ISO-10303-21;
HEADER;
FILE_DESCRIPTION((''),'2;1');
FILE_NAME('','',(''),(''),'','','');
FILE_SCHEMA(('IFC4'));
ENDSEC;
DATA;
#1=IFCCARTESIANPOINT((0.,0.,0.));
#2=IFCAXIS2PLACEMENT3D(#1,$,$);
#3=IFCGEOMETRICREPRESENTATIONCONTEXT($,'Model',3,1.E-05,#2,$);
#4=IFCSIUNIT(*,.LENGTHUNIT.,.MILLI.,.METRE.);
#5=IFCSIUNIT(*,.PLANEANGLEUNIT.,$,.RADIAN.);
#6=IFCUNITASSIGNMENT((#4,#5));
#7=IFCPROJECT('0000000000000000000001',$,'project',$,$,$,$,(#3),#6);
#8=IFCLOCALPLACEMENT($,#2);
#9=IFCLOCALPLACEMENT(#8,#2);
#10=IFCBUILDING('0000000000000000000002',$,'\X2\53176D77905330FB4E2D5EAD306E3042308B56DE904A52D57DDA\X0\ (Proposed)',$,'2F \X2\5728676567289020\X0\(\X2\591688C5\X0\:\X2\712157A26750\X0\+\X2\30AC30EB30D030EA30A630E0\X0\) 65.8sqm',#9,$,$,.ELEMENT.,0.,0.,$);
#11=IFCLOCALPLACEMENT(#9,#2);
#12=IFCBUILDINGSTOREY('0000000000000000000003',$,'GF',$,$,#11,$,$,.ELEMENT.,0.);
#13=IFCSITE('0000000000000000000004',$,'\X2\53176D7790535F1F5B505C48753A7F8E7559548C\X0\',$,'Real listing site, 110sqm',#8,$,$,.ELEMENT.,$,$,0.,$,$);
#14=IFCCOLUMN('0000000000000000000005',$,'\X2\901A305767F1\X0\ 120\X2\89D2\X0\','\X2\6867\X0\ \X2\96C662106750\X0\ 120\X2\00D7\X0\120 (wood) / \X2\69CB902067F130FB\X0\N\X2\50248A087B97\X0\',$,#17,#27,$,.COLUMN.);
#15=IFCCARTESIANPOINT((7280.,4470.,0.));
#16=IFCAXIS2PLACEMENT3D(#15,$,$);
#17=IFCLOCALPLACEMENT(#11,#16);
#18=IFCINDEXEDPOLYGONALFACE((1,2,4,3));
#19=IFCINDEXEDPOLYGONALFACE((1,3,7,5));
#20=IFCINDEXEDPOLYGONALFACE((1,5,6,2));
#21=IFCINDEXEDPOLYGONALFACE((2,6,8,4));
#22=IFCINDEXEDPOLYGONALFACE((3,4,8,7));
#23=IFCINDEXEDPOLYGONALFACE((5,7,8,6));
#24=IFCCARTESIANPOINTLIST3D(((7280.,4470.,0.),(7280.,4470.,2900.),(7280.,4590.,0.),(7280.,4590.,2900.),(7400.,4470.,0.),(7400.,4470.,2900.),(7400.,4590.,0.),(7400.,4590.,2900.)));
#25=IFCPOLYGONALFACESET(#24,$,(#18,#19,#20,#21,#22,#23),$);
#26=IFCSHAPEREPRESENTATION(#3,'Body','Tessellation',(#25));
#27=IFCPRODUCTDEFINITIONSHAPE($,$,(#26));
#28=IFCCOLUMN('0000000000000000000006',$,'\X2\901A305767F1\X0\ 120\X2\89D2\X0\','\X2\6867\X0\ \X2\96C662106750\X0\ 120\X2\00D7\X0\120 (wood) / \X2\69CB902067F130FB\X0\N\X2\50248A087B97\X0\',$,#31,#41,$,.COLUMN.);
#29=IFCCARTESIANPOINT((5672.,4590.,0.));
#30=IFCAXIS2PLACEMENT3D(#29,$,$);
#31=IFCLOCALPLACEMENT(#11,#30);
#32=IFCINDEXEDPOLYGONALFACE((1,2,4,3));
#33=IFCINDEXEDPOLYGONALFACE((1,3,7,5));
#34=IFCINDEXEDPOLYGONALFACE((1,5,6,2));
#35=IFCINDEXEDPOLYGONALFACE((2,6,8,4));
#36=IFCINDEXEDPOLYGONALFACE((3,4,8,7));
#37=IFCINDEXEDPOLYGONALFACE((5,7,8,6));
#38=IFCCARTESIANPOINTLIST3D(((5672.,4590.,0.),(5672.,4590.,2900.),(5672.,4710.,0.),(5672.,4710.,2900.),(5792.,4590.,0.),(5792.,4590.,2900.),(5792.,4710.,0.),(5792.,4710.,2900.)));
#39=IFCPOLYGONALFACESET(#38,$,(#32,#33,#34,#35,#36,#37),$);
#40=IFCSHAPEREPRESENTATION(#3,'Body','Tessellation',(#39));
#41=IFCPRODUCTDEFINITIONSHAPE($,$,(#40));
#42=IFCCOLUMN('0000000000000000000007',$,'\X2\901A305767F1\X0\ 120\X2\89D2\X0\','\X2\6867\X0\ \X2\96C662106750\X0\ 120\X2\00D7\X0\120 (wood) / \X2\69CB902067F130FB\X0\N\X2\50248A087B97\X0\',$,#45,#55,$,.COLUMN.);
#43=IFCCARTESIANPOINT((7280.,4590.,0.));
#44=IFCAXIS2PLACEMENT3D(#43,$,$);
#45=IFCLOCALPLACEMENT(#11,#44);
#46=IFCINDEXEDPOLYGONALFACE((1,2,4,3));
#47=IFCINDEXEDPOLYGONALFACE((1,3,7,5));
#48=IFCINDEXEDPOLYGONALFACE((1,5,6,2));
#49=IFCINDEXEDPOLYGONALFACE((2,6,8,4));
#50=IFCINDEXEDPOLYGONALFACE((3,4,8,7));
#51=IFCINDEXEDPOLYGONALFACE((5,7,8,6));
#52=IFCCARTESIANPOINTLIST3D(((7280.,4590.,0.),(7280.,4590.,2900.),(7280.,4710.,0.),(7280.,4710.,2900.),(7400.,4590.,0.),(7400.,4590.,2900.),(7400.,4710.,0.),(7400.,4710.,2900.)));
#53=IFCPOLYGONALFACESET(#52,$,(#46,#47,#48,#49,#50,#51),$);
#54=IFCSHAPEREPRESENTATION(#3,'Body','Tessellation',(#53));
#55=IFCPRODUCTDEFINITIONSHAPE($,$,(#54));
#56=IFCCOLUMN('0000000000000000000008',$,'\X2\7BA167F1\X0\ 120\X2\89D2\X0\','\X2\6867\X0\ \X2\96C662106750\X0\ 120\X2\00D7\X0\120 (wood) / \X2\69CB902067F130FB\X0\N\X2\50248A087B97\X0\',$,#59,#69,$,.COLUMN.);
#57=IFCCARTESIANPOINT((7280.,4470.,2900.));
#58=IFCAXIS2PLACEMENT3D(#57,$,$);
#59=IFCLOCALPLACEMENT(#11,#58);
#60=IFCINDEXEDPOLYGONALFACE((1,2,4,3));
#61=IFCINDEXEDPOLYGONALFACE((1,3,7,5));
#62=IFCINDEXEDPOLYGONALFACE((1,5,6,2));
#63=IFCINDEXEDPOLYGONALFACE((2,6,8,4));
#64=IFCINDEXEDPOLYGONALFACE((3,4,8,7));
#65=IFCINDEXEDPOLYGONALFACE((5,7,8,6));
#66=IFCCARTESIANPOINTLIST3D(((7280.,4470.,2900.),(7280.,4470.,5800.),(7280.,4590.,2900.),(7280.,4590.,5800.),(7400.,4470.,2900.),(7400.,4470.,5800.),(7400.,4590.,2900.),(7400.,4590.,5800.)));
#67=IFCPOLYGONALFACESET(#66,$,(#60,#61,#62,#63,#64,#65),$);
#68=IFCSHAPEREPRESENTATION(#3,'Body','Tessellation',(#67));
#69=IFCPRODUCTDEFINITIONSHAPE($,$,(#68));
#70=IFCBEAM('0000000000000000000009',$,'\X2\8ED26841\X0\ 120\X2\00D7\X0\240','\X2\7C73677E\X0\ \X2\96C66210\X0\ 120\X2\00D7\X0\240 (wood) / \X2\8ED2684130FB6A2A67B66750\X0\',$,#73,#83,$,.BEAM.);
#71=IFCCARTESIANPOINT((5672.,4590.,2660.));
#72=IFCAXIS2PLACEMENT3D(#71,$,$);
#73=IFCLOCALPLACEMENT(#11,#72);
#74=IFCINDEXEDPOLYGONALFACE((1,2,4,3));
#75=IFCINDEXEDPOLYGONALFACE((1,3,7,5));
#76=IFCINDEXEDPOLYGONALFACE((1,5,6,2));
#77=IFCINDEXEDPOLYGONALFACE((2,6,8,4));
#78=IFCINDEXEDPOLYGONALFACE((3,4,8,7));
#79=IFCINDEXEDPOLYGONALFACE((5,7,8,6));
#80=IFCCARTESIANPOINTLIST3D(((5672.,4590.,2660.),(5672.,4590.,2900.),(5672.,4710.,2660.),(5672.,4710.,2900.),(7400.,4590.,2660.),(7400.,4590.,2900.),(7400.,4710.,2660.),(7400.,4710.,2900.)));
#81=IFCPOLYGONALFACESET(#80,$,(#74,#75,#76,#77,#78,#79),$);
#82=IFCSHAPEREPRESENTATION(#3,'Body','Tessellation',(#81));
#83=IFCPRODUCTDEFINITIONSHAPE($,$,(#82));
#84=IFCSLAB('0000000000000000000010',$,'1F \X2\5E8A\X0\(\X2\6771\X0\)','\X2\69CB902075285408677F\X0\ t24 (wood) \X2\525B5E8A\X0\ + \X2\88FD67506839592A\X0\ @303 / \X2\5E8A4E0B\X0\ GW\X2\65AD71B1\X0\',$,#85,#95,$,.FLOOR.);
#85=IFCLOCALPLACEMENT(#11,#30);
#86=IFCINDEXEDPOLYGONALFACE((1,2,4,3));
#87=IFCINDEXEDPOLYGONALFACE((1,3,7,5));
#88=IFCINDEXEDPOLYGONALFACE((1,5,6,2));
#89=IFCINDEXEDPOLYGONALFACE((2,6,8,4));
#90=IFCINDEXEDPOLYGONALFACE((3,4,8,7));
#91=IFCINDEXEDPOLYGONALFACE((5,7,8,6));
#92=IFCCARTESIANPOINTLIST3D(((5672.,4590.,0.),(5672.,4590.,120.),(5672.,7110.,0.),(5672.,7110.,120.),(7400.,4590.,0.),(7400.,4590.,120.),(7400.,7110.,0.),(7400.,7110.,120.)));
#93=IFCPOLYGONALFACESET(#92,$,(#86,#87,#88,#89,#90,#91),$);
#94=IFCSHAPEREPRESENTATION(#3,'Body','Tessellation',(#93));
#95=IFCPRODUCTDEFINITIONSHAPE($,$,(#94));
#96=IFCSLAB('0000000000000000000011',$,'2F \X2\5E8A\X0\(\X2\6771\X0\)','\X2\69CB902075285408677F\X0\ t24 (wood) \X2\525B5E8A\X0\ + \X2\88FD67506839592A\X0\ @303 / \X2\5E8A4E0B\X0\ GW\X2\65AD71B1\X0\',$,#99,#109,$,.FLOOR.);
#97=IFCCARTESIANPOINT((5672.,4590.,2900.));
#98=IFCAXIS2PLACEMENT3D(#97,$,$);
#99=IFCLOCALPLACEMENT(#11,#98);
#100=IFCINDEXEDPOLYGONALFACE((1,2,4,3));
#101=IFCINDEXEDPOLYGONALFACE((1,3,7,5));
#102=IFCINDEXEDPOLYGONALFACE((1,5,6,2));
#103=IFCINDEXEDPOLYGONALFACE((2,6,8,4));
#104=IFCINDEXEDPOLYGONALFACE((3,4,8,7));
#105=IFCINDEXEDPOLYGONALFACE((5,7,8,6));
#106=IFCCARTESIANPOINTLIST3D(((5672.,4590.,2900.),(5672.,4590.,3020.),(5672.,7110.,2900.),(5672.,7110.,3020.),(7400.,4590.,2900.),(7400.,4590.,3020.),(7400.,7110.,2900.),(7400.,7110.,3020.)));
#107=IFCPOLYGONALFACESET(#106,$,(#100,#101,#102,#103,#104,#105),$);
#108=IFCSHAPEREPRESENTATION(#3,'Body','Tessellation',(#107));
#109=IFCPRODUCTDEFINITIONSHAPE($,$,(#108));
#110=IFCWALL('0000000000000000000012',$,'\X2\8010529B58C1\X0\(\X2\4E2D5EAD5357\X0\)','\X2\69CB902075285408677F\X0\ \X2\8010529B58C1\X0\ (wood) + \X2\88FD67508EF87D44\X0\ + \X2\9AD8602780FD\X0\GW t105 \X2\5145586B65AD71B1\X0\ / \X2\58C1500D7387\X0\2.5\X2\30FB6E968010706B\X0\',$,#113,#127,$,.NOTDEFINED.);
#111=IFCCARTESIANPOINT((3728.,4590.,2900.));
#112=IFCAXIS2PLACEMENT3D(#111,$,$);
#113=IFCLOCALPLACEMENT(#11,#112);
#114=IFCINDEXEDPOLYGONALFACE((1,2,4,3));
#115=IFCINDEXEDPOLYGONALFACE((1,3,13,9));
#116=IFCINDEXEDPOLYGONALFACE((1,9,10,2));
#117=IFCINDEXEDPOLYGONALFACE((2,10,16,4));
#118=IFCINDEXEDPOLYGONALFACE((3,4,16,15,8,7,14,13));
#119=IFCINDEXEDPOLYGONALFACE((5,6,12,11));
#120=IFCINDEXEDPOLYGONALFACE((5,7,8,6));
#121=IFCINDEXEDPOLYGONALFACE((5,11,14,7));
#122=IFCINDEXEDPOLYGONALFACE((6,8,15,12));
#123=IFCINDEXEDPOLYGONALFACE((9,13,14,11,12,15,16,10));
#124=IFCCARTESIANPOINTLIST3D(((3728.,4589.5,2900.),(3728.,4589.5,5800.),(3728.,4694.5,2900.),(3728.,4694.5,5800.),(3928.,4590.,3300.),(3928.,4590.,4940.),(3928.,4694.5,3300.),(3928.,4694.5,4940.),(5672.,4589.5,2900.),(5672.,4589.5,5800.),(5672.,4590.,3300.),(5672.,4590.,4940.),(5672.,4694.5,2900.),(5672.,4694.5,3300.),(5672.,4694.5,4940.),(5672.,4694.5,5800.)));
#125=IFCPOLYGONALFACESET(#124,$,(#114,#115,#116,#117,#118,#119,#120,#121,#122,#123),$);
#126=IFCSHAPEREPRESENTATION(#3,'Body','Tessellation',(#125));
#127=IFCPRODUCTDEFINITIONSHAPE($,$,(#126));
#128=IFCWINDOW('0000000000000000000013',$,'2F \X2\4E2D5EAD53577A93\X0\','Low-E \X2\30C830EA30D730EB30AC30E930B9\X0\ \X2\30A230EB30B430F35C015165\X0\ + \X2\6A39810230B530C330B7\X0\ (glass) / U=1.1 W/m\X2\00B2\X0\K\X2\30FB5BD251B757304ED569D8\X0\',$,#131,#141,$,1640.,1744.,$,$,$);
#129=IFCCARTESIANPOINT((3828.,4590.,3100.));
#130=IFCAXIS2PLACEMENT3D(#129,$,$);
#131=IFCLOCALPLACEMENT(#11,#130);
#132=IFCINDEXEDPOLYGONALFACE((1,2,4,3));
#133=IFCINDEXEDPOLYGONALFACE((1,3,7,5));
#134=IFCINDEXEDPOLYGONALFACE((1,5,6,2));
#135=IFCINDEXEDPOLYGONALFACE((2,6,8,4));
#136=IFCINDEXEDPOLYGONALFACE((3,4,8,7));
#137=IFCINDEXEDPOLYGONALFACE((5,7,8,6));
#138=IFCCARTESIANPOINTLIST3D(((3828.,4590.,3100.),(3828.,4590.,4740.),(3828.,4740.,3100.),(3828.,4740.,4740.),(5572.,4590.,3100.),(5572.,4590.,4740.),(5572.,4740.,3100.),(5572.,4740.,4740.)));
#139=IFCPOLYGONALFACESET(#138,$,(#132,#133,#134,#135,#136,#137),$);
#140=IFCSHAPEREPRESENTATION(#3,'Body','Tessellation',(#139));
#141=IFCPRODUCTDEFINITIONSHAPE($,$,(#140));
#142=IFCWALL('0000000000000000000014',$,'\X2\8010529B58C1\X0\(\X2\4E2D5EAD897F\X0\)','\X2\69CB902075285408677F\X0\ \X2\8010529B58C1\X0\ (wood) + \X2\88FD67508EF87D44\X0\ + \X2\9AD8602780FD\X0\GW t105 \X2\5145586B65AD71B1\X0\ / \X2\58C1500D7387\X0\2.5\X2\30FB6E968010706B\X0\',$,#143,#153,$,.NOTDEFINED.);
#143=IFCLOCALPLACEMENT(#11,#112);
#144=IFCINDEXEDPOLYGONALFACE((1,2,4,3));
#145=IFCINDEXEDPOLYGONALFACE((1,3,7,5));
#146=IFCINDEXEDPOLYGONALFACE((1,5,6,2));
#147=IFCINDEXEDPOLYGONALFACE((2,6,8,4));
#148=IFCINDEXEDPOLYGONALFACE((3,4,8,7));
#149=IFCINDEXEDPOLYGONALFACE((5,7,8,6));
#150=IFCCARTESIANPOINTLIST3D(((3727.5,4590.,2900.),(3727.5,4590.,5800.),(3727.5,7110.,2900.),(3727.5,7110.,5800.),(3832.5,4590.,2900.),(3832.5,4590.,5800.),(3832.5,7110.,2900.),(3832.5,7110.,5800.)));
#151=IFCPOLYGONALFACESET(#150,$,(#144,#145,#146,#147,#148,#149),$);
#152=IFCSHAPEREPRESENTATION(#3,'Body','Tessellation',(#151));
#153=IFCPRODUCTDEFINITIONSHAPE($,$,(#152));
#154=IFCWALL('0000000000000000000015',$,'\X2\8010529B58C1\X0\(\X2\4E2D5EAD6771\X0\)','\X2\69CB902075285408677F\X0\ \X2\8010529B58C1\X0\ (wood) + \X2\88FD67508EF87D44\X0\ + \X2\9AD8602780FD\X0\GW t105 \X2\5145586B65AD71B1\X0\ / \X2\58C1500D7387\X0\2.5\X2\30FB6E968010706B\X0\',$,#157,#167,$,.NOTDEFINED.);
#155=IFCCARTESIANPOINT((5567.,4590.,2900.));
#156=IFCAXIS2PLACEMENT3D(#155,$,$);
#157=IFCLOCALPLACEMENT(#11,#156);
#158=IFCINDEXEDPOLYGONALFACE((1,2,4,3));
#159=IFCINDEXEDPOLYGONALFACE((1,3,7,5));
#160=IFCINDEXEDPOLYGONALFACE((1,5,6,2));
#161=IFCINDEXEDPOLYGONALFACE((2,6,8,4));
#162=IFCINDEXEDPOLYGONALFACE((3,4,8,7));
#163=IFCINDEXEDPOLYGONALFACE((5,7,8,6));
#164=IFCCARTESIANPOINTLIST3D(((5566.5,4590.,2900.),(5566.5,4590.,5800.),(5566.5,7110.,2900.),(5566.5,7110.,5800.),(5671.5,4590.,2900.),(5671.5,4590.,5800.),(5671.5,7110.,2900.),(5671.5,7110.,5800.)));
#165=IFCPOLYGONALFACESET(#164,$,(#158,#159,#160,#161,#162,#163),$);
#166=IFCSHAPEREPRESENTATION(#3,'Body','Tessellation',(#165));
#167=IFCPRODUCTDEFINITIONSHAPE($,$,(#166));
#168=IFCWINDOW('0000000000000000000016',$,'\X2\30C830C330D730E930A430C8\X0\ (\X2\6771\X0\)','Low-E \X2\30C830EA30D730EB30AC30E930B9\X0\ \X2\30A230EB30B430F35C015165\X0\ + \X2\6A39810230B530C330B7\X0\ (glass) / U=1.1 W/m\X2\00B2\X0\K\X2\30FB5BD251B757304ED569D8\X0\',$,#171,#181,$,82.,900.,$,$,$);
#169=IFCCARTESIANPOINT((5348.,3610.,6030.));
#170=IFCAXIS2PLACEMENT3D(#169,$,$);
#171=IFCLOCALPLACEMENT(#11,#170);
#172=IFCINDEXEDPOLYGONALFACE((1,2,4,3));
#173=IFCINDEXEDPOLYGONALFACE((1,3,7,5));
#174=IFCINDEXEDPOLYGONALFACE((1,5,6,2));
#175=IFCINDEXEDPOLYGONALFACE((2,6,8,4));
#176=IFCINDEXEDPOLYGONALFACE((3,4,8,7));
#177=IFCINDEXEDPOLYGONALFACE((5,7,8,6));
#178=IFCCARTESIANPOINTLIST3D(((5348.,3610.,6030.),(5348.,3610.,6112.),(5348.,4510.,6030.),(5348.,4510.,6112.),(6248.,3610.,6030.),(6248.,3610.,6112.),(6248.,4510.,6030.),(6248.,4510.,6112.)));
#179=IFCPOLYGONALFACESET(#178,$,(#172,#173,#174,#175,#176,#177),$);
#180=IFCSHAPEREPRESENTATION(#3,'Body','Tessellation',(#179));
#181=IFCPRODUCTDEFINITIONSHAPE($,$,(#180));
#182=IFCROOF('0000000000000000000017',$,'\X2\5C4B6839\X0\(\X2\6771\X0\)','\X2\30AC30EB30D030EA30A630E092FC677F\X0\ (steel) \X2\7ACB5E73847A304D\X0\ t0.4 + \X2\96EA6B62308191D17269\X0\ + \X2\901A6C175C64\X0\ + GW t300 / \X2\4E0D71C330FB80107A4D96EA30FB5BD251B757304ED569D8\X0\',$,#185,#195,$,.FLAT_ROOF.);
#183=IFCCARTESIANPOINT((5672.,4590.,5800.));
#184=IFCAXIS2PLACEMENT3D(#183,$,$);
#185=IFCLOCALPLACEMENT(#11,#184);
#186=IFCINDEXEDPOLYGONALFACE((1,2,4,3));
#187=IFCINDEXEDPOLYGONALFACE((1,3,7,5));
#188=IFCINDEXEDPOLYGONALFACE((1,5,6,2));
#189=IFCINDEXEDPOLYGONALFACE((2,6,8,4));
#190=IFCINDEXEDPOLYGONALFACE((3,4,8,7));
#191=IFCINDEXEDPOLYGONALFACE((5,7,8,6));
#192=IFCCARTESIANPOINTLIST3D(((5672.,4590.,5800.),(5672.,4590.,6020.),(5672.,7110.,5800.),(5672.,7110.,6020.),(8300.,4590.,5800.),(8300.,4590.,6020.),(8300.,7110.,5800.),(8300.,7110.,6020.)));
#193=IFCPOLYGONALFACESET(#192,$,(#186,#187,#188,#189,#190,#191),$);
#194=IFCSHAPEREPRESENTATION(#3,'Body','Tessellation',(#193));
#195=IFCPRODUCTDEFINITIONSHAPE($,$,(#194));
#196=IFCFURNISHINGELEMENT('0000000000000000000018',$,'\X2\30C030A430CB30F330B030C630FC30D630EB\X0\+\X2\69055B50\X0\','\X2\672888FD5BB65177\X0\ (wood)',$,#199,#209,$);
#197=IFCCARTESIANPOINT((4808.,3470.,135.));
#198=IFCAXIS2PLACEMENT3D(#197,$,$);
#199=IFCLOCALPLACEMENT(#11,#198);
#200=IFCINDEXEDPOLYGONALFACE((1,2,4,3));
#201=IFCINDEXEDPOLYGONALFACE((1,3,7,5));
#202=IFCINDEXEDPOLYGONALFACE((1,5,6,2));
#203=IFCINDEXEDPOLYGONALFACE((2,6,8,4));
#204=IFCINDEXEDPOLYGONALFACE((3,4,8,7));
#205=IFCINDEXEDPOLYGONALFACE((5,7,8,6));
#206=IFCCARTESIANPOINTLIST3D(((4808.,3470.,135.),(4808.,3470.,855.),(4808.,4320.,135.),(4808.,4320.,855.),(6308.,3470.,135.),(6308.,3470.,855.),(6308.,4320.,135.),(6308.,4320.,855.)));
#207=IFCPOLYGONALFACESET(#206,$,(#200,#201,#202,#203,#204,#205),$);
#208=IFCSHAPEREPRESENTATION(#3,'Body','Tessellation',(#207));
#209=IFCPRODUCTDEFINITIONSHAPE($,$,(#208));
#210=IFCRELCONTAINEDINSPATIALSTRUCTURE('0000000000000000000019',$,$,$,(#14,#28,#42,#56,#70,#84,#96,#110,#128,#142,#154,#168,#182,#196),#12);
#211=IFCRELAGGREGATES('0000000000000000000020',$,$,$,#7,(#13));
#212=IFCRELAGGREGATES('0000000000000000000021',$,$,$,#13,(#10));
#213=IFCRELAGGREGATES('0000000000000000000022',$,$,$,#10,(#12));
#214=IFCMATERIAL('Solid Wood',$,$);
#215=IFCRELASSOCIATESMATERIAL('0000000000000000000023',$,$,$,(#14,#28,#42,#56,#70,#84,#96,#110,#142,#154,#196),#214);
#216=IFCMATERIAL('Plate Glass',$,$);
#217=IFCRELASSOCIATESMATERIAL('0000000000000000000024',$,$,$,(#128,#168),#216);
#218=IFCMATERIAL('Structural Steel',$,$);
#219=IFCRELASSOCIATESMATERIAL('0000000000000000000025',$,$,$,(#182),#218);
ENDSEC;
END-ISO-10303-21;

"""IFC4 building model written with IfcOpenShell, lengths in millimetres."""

from ifc_helpers import new_model, si_unit, frame, frame_2d, origin, place, context, project, spatial, rectangle, extrude, material, element, fill, save


model = new_model("IFC4")

# Units and contexts
model_context = context("Model", 3, precision=1e-05, world=origin())
ifc_project = project(units=[si_unit("LENGTHUNIT", "METRE", prefix="MILLI"), si_unit("PLANEANGLEUNIT", "RADIAN")], contexts=[model_context])

# Site, building, storey
site_placement = place(None, origin())
site = spatial("IfcSite", under=ifc_project, at=site_placement, Name="北海道弟子屈町美留和", ObjectType="Real listing site, 110sqm", CompositionType="ELEMENT", RefElevation=0.0)
building_placement = place(site_placement, origin())
building = spatial("IfcBuilding", under=site, at=building_placement, Name="北海道・中庭のある回遊動線 (Proposed)", ObjectType="2F 在来木造(外装:無垢材+ガルバリウム) 65.8sqm", CompositionType="ELEMENT", ElevationOfRefHeight=0.0, ElevationOfTerrain=0.0)
storey_placement = place(building_placement, origin())
storey = spatial("IfcBuildingStorey", under=building, at=storey_placement, Name="GF", CompositionType="ELEMENT", Elevation=0.0)

# Columns
ifc_material_1 = material(Name="Solid Wood")
column_1_placement = place(storey_placement, frame((7280.0, 4470.0, 0.0)))
element("IfcColumn", 1, at=column_1_placement, inside=storey, material=ifc_material_1, Name="通し柱 120角", Description="桧 集成材 120×120 (wood) / 構造柱・N値計算", PredefinedType="COLUMN", context=model_context, shape_type="SweptSolid", body=[
    extrude(rectangle(XDim=120.0, YDim=120.0, at=frame_2d((60.0, 60.0))), frame((7280.0, 4470.0, 0.0)), (0.0, 0.0, 1.0), 2900.0),
])
column_2_placement = place(storey_placement, frame((5672.0, 4590.0, 0.0)))
element("IfcColumn", 2, at=column_2_placement, inside=storey, material=ifc_material_1, Name="通し柱 120角", Description="桧 集成材 120×120 (wood) / 構造柱・N値計算", PredefinedType="COLUMN", context=model_context, shape_type="SweptSolid", body=[
    extrude(rectangle(XDim=120.0, YDim=120.0, at=frame_2d((60.0, 60.0))), frame((5672.0, 4590.0, 0.0)), (0.0, 0.0, 1.0), 2900.0),
])
column_3_placement = place(storey_placement, frame((7280.0, 4590.0, 0.0)))
element("IfcColumn", 3, at=column_3_placement, inside=storey, material=ifc_material_1, Name="通し柱 120角", Description="桧 集成材 120×120 (wood) / 構造柱・N値計算", PredefinedType="COLUMN", context=model_context, shape_type="SweptSolid", body=[
    extrude(rectangle(XDim=120.0, YDim=120.0, at=frame_2d((60.0, 60.0))), frame((7280.0, 4590.0, 0.0)), (0.0, 0.0, 1.0), 2900.0),
])
column_4_placement = place(storey_placement, frame((7280.0, 4470.0, 2900.0)))
element("IfcColumn", 4, at=column_4_placement, inside=storey, material=ifc_material_1, Name="管柱 120角", Description="桧 集成材 120×120 (wood) / 構造柱・N値計算", PredefinedType="COLUMN", context=model_context, shape_type="SweptSolid", body=[
    extrude(rectangle(XDim=120.0, YDim=120.0, at=frame_2d((60.0, 60.0))), frame((7280.0, 4470.0, 2900.0)), (0.0, 0.0, 1.0), 2900.0),
])

# Beam
beam_1_placement = place(storey_placement, frame((5672.0, 4590.0, 2660.0)))
element("IfcBeam", 5, at=beam_1_placement, inside=storey, material=ifc_material_1, Name="軒桁 120×240", Description="米松 集成 120×240 (wood) / 軒桁・横架材", PredefinedType="BEAM", context=model_context, shape_type="SweptSolid", body=[
    extrude(rectangle(XDim=1728.0, YDim=120.0, at=frame_2d((864.0, 60.0))), frame((5672.0, 4590.0, 2660.0)), (0.0, 0.0, 1.0), 240.0),
])

# Slabs
slab_1_placement = place(storey_placement, frame((5672.0, 4590.0, 0.0)))
element("IfcSlab", 6, at=slab_1_placement, inside=storey, material=ifc_material_1, Name="1F 床(東)", Description="構造用合板 t24 (wood) 剛床 + 製材根太 @303 / 床下 GW断熱", PredefinedType="FLOOR", context=model_context, shape_type="SweptSolid", body=[
    extrude(rectangle(XDim=1728.0, YDim=2520.0, at=frame_2d((864.0, 1260.0))), frame((5672.0, 4590.0, 0.0)), (0.0, 0.0, 1.0), 120.0),
])
slab_2_placement = place(storey_placement, frame((5672.0, 4590.0, 2900.0)))
element("IfcSlab", 7, at=slab_2_placement, inside=storey, material=ifc_material_1, Name="2F 床(東)", Description="構造用合板 t24 (wood) 剛床 + 製材根太 @303 / 床下 GW断熱", PredefinedType="FLOOR", context=model_context, shape_type="SweptSolid", body=[
    extrude(rectangle(XDim=1728.0, YDim=2520.0, at=frame_2d((864.0, 1260.0))), frame((5672.0, 4590.0, 2900.0)), (0.0, 0.0, 1.0), 120.0),
])

# Wall, opening, window
wall_1_placement = place(storey_placement, frame((3728.0, 4590.0, 2900.0)))
wall_1 = element("IfcWall", 8, at=wall_1_placement, inside=storey, material=ifc_material_1, Name="耐力壁(中庭南)", Description="構造用合板 耐力壁 (wood) + 製材軸組 + 高性能GW t105 充填断熱 / 壁倍率2.5・準耐火", PredefinedType="NOTDEFINED", context=model_context, shape_type="SweptSolid", body=[
    extrude(rectangle(XDim=1944.0, YDim=105.0, at=frame_2d((972.0, 52.0))), frame((3728.0, 4590.0, 2900.0)), (0.0, 0.0, 1.0), 2900.0),
])
opening_placement = place(storey_placement, frame((3828.0, 4590.0, 3100.0)))
opening = element("IfcOpeningElement", 9, at=opening_placement, cuts=wall_1, PredefinedType="NOTDEFINED", context=model_context, shape_type="SweptSolid", body=[
    extrude(rectangle(XDim=1744.0, YDim=150.0, at=frame_2d((872.0, 75.0))), frame((3828.0, 4590.0, 3100.0)), (0.0, 0.0, 1.0), 1640.0),
])
ifc_material_2 = material(Name="Plate Glass")
window_1_placement = place(storey_placement, frame((3828.0, 4590.0, 3100.0)))
window_1 = element("IfcWindow", 10, at=window_1_placement, inside=storey, material=ifc_material_2, Name="2F 中庭南窓", Description="Low-E トリプルガラス アルゴン封入 + 樹脂サッシ (glass) / U=1.1 W/m²K・寒冷地仕様", OverallHeight=1640.0, OverallWidth=1744.0, context=model_context, shape_type="SweptSolid", body=[
    extrude(rectangle(XDim=1744.0, YDim=150.0, at=frame_2d((872.0, 75.0))), frame((3828.0, 4590.0, 3100.0)), (0.0, 0.0, 1.0), 1640.0),
])
fill(opening, window_1)

# Walls
wall_2_placement = place(storey_placement, frame((3728.0, 4590.0, 2900.0)))
element("IfcWall", 11, at=wall_2_placement, inside=storey, material=ifc_material_1, Name="耐力壁(中庭西)", Description="構造用合板 耐力壁 (wood) + 製材軸組 + 高性能GW t105 充填断熱 / 壁倍率2.5・準耐火", PredefinedType="NOTDEFINED", context=model_context, shape_type="SweptSolid", body=[
    extrude(rectangle(XDim=105.0, YDim=2520.0, at=frame_2d((52.0, 1260.0))), frame((3728.0, 4590.0, 2900.0)), (0.0, 0.0, 1.0), 2900.0),
])
wall_3_placement = place(storey_placement, frame((5567.0, 4590.0, 2900.0)))
element("IfcWall", 12, at=wall_3_placement, inside=storey, material=ifc_material_1, Name="耐力壁(中庭東)", Description="構造用合板 耐力壁 (wood) + 製材軸組 + 高性能GW t105 充填断熱 / 壁倍率2.5・準耐火", PredefinedType="NOTDEFINED", context=model_context, shape_type="SweptSolid", body=[
    extrude(rectangle(XDim=105.0, YDim=2520.0, at=frame_2d((52.0, 1260.0))), frame((5567.0, 4590.0, 2900.0)), (0.0, 0.0, 1.0), 2900.0),
])

# Window
window_2_placement = place(storey_placement, frame((5348.0, 3610.0, 6030.0)))
element("IfcWindow", 13, at=window_2_placement, inside=storey, material=ifc_material_2, Name="トップライト (東)", Description="Low-E トリプルガラス アルゴン封入 + 樹脂サッシ (glass) / U=1.1 W/m²K・寒冷地仕様", OverallHeight=82.0, OverallWidth=900.0, context=model_context, shape_type="SweptSolid", body=[
    extrude(rectangle(XDim=900.0, YDim=900.0, at=frame_2d((450.0, 450.0))), frame((5348.0, 3610.0, 6030.0)), (0.0, 0.0, 1.0), 82.0),
])

# Roof
ifc_material_3 = material(Name="Structural Steel")
for number, where, name in (
    (14, (5672.0, 4590.0, 5800.0), "屋根(東)"),
):
    element("IfcRoof", number, at=place(storey_placement, frame(where)), inside=storey, material=ifc_material_3, Name=name, Description="ガルバリウム鋼板 (steel) 立平葺き t0.4 + 雪止め金物 + 通気層 + GW t300 / 不燃・耐積雪・寒冷地仕様", PredefinedType="FLAT_ROOF", context=model_context, shape_type="SweptSolid", body=[
        extrude(rectangle(XDim=2628.0, YDim=2520.0, at=frame_2d((1314.0, 1260.0))), frame((5672.0, 4590.0, 5800.0)), (0.0, 0.0, 1.0), 220.0),
    ])

# Furnishing element
furnishing_1_placement = place(storey_placement, frame((4808.0, 3470.0, 135.0)))
element("IfcFurnishingElement", 15, at=furnishing_1_placement, inside=storey, material=ifc_material_1, Name="ダイニングテーブル+椅子", Description="木製家具 (wood)", context=model_context, shape_type="SweptSolid", body=[
    extrude(rectangle(XDim=1500.0, YDim=850.0, at=frame_2d((750.0, 425.0))), frame((4808.0, 3470.0, 135.0)), (0.0, 0.0, 1.0), 720.0),
])

save(model, "model.ifc")
